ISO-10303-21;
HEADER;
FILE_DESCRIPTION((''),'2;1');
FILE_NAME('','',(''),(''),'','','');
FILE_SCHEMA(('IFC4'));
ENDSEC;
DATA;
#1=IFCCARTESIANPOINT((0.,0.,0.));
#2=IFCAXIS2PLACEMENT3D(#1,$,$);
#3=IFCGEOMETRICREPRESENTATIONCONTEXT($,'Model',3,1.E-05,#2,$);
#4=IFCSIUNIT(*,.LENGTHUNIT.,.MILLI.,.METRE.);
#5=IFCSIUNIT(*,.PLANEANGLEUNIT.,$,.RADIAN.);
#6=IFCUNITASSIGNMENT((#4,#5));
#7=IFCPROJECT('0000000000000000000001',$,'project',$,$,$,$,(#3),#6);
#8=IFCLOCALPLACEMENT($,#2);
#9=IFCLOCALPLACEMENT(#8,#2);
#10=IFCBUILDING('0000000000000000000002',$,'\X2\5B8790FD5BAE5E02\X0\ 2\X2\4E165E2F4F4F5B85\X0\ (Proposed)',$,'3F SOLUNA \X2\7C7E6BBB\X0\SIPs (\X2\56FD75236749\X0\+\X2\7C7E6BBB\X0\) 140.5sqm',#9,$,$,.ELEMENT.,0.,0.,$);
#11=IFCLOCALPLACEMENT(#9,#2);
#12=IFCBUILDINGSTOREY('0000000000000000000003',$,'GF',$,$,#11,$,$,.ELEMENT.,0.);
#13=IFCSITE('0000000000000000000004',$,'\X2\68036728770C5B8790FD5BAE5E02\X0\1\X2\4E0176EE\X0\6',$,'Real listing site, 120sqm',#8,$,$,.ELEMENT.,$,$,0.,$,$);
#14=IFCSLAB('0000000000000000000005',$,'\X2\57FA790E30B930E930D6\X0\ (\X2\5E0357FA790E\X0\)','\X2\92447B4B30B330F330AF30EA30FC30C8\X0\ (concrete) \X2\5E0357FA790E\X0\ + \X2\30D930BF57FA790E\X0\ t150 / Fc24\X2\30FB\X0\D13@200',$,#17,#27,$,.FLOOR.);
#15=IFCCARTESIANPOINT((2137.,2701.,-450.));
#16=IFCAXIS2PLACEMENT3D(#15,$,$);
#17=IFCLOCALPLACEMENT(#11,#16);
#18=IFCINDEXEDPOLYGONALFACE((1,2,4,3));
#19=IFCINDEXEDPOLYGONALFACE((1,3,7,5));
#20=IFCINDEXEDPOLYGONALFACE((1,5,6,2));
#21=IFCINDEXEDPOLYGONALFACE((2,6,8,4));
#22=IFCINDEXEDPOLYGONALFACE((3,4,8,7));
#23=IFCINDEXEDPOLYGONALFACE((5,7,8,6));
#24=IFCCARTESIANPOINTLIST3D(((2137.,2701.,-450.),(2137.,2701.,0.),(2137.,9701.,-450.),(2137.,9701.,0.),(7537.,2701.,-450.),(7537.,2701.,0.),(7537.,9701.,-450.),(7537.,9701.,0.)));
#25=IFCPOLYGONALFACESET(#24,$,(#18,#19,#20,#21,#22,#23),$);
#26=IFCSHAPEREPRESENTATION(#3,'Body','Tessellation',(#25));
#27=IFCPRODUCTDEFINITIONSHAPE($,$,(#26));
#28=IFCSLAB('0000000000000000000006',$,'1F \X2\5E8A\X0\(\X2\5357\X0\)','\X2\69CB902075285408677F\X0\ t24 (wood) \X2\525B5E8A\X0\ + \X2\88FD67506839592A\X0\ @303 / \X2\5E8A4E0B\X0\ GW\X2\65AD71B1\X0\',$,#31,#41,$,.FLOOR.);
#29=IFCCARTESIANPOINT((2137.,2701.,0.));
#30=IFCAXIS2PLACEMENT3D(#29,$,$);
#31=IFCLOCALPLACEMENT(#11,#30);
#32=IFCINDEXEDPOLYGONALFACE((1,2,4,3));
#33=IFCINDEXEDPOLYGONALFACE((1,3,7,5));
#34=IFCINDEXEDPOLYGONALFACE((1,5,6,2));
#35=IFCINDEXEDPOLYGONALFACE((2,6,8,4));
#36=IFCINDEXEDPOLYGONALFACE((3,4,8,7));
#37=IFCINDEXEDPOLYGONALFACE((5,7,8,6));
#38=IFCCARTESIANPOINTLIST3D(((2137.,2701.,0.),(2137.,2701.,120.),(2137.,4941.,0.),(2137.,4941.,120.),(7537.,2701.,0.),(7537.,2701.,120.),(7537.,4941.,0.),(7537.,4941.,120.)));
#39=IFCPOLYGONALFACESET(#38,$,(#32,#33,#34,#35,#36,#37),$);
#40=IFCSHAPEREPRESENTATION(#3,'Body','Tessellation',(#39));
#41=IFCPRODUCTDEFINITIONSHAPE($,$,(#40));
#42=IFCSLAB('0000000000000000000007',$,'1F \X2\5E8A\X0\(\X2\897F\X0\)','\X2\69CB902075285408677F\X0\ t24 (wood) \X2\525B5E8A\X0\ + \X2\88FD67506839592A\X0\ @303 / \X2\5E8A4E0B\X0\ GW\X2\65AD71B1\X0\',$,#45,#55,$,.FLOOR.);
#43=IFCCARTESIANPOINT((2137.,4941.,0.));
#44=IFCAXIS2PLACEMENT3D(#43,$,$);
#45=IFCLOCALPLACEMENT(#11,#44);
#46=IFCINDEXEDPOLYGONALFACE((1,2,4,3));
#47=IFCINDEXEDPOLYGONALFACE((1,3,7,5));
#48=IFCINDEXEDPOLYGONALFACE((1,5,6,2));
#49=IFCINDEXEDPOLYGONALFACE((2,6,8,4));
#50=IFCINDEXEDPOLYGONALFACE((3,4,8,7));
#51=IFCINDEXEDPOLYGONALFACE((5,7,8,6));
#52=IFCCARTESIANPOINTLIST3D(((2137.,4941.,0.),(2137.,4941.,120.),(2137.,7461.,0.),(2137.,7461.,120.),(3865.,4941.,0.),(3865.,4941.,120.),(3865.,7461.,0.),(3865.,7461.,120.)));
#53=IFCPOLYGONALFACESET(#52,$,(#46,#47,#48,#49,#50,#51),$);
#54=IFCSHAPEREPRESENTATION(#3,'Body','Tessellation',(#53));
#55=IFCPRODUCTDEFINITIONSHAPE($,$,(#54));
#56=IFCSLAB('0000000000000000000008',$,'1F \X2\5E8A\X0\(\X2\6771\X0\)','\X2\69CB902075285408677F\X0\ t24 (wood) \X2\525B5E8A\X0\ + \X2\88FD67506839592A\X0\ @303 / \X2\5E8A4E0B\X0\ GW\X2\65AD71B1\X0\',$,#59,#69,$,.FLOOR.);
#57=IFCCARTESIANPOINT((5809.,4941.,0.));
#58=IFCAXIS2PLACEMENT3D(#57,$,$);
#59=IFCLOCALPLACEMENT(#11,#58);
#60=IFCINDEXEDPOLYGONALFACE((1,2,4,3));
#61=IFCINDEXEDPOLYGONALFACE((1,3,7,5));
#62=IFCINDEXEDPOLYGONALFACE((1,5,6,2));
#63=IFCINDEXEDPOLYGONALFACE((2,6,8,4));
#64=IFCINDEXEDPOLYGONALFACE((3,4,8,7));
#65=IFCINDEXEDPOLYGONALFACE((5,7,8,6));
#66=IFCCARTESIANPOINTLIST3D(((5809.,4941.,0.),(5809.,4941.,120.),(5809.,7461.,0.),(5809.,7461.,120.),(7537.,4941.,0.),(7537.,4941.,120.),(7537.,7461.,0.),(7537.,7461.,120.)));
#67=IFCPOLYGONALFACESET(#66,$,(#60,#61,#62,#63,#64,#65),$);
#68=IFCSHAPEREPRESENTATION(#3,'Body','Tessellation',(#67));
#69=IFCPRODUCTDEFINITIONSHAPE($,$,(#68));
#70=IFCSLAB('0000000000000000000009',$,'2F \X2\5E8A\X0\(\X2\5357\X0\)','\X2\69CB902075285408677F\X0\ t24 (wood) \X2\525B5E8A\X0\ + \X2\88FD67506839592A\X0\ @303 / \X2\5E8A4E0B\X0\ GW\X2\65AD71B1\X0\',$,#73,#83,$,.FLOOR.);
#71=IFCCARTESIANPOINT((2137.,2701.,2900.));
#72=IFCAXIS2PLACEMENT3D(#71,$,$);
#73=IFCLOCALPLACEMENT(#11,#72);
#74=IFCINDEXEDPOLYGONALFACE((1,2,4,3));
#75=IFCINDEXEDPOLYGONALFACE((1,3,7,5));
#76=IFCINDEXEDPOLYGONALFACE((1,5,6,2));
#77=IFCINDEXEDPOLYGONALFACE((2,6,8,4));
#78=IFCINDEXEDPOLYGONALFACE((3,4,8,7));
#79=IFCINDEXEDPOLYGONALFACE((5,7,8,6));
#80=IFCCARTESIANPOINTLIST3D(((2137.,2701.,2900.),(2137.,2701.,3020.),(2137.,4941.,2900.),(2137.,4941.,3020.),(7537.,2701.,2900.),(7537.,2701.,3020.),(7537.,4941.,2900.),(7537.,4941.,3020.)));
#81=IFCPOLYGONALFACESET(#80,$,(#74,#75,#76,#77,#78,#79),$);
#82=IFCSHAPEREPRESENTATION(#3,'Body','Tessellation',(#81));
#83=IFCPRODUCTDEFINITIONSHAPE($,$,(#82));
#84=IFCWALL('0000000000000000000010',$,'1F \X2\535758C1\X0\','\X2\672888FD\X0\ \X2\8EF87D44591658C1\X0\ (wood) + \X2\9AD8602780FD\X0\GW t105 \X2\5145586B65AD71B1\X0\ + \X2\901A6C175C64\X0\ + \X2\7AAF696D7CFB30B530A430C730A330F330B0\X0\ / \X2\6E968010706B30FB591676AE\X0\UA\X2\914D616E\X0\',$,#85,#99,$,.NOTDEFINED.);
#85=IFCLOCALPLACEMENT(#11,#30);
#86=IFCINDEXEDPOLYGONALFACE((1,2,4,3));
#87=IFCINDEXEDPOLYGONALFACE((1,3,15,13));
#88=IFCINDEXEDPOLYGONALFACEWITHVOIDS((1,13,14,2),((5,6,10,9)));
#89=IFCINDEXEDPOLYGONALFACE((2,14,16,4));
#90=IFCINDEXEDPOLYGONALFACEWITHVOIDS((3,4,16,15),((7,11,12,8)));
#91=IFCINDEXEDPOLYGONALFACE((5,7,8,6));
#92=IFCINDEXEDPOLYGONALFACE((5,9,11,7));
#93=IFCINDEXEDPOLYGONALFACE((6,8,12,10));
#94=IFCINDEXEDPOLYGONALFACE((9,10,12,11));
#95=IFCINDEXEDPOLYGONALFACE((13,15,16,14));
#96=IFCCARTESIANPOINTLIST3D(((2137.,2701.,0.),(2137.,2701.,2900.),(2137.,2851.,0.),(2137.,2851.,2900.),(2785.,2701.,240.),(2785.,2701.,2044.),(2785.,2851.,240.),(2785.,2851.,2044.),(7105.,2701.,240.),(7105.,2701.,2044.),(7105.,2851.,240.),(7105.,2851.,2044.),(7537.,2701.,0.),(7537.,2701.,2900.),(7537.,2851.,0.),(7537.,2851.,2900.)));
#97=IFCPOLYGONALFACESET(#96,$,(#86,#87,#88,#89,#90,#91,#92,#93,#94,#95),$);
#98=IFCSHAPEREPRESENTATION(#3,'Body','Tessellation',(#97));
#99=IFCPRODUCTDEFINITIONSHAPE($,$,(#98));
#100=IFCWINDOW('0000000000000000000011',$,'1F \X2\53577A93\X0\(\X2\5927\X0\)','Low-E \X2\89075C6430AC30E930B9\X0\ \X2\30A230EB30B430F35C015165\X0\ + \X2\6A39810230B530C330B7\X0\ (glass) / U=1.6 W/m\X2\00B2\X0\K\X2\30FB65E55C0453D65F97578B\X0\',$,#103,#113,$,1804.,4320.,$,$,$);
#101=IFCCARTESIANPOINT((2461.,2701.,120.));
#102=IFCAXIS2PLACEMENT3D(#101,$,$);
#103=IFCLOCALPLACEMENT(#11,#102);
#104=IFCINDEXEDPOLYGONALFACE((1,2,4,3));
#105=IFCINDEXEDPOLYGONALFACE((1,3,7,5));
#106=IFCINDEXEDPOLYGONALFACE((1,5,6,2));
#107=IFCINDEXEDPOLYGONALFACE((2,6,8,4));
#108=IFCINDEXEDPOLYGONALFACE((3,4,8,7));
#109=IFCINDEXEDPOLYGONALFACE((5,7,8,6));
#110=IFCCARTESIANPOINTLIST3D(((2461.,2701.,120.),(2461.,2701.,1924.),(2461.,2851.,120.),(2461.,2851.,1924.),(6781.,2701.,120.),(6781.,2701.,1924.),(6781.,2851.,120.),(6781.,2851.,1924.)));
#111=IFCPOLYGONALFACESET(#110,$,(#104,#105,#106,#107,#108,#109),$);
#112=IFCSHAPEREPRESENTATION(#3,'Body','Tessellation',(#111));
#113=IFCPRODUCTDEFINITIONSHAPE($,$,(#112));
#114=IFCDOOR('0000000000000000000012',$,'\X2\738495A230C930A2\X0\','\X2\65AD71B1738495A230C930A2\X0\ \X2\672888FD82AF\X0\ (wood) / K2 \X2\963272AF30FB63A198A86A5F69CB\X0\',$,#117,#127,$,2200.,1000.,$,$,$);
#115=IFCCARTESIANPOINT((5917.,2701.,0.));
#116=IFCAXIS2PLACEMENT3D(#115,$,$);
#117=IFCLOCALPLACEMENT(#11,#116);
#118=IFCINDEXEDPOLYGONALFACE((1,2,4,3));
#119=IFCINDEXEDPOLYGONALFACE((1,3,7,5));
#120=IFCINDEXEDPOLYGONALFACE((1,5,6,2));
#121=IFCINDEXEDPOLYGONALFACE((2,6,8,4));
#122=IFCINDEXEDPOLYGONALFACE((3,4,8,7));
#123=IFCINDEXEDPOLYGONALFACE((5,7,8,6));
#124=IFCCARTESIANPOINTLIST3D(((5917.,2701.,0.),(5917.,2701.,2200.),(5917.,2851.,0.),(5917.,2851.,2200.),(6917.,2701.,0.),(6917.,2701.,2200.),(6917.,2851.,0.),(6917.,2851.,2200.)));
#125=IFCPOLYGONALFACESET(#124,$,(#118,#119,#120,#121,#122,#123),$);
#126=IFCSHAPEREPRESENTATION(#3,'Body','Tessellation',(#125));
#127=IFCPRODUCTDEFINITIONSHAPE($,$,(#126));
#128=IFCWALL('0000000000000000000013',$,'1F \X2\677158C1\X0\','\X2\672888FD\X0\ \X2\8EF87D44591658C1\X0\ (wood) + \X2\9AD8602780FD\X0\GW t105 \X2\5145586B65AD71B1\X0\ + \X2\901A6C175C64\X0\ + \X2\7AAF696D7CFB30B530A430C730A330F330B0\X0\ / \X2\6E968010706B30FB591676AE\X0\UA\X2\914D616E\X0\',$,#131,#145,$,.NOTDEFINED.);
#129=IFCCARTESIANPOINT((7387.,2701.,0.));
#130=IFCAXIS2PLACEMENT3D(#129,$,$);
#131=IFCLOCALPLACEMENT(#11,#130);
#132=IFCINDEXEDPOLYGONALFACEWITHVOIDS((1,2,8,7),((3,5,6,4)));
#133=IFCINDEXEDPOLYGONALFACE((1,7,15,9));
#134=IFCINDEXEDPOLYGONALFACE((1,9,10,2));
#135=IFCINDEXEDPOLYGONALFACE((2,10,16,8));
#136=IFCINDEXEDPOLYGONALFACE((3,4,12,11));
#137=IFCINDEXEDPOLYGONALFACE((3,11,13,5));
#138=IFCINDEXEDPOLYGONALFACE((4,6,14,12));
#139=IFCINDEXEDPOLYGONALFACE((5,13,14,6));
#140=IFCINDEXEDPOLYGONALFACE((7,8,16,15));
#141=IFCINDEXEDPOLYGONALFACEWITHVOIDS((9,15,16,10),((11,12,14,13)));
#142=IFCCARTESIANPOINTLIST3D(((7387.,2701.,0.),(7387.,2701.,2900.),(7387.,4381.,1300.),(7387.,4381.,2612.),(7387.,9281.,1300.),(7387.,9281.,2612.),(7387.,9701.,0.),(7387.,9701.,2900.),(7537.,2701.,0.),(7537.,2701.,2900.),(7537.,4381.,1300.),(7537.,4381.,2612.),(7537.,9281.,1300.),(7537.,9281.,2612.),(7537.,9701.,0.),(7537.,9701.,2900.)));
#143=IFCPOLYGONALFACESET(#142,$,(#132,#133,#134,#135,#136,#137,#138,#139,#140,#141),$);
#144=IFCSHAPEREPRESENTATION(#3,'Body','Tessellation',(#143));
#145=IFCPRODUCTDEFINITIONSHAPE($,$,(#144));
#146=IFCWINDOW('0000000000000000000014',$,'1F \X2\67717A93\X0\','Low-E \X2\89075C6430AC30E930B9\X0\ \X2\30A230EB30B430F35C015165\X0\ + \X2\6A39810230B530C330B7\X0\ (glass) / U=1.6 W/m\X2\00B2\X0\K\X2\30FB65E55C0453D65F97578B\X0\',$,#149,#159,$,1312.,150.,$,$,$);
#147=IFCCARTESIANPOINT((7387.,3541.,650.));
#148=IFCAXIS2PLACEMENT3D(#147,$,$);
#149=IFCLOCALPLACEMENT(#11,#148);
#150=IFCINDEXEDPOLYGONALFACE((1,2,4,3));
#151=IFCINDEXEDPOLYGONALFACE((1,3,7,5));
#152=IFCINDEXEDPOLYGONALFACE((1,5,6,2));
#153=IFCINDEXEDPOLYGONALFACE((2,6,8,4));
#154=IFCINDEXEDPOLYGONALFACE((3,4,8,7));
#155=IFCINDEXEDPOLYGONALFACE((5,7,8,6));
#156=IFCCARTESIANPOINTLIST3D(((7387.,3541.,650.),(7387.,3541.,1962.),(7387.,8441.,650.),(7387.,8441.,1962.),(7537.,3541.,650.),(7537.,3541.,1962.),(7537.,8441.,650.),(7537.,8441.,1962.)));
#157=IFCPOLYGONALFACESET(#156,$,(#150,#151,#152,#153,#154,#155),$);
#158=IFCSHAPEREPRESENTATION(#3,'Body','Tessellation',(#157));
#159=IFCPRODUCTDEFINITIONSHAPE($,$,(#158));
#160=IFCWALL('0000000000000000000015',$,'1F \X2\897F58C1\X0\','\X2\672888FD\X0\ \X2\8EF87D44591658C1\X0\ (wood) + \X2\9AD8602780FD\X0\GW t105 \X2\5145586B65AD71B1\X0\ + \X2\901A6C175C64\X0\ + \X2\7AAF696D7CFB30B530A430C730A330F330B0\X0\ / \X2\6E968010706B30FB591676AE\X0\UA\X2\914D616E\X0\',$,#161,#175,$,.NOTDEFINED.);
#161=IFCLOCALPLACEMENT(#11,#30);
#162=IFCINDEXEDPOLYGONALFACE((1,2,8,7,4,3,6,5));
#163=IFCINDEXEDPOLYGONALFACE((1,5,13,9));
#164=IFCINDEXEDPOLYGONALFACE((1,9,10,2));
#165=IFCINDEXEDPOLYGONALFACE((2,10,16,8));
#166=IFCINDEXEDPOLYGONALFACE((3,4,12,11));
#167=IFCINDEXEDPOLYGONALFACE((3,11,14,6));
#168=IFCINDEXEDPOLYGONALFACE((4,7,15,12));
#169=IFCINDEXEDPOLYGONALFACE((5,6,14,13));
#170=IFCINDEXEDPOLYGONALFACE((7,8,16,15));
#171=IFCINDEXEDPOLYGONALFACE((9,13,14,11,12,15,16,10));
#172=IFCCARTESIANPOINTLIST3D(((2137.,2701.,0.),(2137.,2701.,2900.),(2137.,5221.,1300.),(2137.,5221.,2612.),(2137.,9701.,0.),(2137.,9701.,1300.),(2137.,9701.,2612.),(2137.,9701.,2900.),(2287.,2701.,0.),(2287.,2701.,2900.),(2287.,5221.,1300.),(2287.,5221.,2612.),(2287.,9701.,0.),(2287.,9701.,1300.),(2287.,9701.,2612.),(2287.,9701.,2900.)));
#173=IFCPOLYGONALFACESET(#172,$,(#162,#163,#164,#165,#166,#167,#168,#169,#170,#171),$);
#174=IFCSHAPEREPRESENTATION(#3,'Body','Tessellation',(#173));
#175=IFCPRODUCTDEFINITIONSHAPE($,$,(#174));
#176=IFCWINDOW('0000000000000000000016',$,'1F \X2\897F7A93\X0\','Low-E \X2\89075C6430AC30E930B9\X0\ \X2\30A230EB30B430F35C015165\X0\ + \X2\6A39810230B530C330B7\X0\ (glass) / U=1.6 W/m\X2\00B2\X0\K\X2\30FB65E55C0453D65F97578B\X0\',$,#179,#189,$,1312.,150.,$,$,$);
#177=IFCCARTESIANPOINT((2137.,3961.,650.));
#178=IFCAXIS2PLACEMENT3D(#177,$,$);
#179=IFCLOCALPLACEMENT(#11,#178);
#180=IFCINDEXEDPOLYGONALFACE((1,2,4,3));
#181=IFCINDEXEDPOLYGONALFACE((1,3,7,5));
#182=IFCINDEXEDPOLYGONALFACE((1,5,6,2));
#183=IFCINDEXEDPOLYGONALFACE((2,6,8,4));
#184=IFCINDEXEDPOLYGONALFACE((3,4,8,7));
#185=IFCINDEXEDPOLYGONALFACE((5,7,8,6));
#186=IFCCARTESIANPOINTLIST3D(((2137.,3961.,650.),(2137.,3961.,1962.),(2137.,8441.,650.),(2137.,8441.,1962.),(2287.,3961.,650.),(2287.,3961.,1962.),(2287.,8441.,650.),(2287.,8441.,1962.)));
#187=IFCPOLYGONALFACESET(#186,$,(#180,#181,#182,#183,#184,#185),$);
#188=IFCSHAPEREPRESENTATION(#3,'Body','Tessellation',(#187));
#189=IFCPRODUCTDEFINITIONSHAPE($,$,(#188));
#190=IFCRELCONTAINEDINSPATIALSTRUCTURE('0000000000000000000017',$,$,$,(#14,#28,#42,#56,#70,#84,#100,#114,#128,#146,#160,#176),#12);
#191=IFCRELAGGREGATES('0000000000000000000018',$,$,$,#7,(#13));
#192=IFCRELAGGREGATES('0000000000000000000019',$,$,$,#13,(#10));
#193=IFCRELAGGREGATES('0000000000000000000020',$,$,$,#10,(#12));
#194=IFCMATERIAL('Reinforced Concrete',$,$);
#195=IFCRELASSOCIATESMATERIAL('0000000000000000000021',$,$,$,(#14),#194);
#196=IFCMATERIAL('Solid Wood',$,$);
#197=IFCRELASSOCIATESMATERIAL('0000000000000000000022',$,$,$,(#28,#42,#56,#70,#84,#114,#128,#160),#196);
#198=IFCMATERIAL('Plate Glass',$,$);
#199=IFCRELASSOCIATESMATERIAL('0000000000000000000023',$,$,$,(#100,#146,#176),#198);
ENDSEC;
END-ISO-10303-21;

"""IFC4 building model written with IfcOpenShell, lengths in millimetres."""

from ifc_helpers import new_model, si_unit, frame, frame_2d, origin, place, context, project, spatial, rectangle, extrude, material, element, fill, save


model = new_model("IFC4")

# Units and contexts
model_context = context("Model", 3, precision=1e-05, world=origin())
ifc_project = project(units=[si_unit("LENGTHUNIT", "METRE", prefix="MILLI"), si_unit("PLANEANGLEUNIT", "RADIAN")], contexts=[model_context])

# Site, building, storey
site_placement = place(None, origin())
site = spatial("IfcSite", under=ifc_project, at=site_placement, Name="栃木県宇都宮市1丁目6", ObjectType="Real listing site, 120sqm", CompositionType="ELEMENT", RefElevation=0.0)
building_placement = place(site_placement, origin())
building = spatial("IfcBuilding", under=site, at=building_placement, Name="宇都宮市 2世帯住宅 (Proposed)", ObjectType="3F SOLUNA 籾殻SIPs (国産杉+籾殻) 140.5sqm", CompositionType="ELEMENT", ElevationOfRefHeight=0.0, ElevationOfTerrain=0.0)
storey_placement = place(building_placement, origin())
storey = spatial("IfcBuildingStorey", under=building, at=storey_placement, Name="GF", CompositionType="ELEMENT", Elevation=0.0)

# Slabs
ifc_material_1 = material(Name="Reinforced Concrete")
slab_1_placement = place(storey_placement, frame((2137.0, 2701.0, -450.0)))
element("IfcSlab", 1, at=slab_1_placement, inside=storey, material=ifc_material_1, Name="基礎スラブ (布基礎)", Description="鉄筋コンクリート (concrete) 布基礎 + ベタ基礎 t150 / Fc24・D13@200", PredefinedType="FLOOR", context=model_context, shape_type="SweptSolid", body=[
    extrude(rectangle(XDim=5400.0, YDim=7000.0, at=frame_2d((2700.0, 3500.0))), frame((2137.0, 2701.0, -450.0)), (0.0, 0.0, 1.0), 450.0),
])
ifc_material_2 = material(Name="Solid Wood")
slab_2_placement = place(storey_placement, frame((2137.0, 2701.0, 0.0)))
element("IfcSlab", 2, at=slab_2_placement, inside=storey, material=ifc_material_2, Name="1F 床(南)", Description="構造用合板 t24 (wood) 剛床 + 製材根太 @303 / 床下 GW断熱", PredefinedType="FLOOR", context=model_context, shape_type="SweptSolid", body=[
    extrude(rectangle(XDim=5400.0, YDim=2240.0, at=frame_2d((2700.0, 1120.0))), frame((2137.0, 2701.0, 0.0)), (0.0, 0.0, 1.0), 120.0),
])
slab_3_placement = place(storey_placement, frame((2137.0, 4941.0, 0.0)))
element("IfcSlab", 3, at=slab_3_placement, inside=storey, material=ifc_material_2, Name="1F 床(西)", Description="構造用合板 t24 (wood) 剛床 + 製材根太 @303 / 床下 GW断熱", PredefinedType="FLOOR", context=model_context, shape_type="SweptSolid", body=[
    extrude(rectangle(XDim=1728.0, YDim=2520.0, at=frame_2d((864.0, 1260.0))), frame((2137.0, 4941.0, 0.0)), (0.0, 0.0, 1.0), 120.0),
])
slab_4_placement = place(storey_placement, frame((5809.0, 4941.0, 0.0)))
element("IfcSlab", 4, at=slab_4_placement, inside=storey, material=ifc_material_2, Name="1F 床(東)", Description="構造用合板 t24 (wood) 剛床 + 製材根太 @303 / 床下 GW断熱", PredefinedType="FLOOR", context=model_context, shape_type="SweptSolid", body=[
    extrude(rectangle(XDim=1728.0, YDim=2520.0, at=frame_2d((864.0, 1260.0))), frame((5809.0, 4941.0, 0.0)), (0.0, 0.0, 1.0), 120.0),
])
slab_5_placement = place(storey_placement, frame((2137.0, 2701.0, 2900.0)))
element("IfcSlab", 5, at=slab_5_placement, inside=storey, material=ifc_material_2, Name="2F 床(南)", Description="構造用合板 t24 (wood) 剛床 + 製材根太 @303 / 床下 GW断熱", PredefinedType="FLOOR", context=model_context, shape_type="SweptSolid", body=[
    extrude(rectangle(XDim=5400.0, YDim=2240.0, at=frame_2d((2700.0, 1120.0))), frame((2137.0, 2701.0, 2900.0)), (0.0, 0.0, 1.0), 120.0),
])

# Wall, openings, window, door
wall_1_placement = place(storey_placement, frame((2137.0, 2701.0, 0.0)))
wall_1 = element("IfcWall", 6, at=wall_1_placement, inside=storey, material=ifc_material_2, Name="1F 南壁", Description="木製 軸組外壁 (wood) + 高性能GW t105 充填断熱 + 通気層 + 窯業系サイディング / 準耐火・外皮UA配慮", PredefinedType="NOTDEFINED", context=model_context, shape_type="SweptSolid", body=[
    extrude(rectangle(XDim=5400.0, YDim=150.0, at=frame_2d((2700.0, 75.0))), frame((2137.0, 2701.0, 0.0)), (0.0, 0.0, 1.0), 2900.0),
])
opening_1_placement = place(storey_placement, frame((2461.0, 2701.0, 120.0)))
opening_1 = element("IfcOpeningElement", 7, at=opening_1_placement, cuts=wall_1, PredefinedType="NOTDEFINED", context=model_context, shape_type="SweptSolid", body=[
    extrude(rectangle(XDim=4320.0, YDim=150.0, at=frame_2d((2160.0, 75.0))), frame((2461.0, 2701.0, 120.0)), (0.0, 0.0, 1.0), 1804.0),
])
opening_2_placement = place(storey_placement, frame((5917.0, 2701.0, 0.0)))
opening_2 = element("IfcOpeningElement", 8, at=opening_2_placement, cuts=wall_1, PredefinedType="NOTDEFINED", context=model_context, shape_type="SweptSolid", body=[
    extrude(rectangle(XDim=1000.0, YDim=150.0, at=frame_2d((500.0, 75.0))), frame((5917.0, 2701.0, 0.0)), (0.0, 0.0, 1.0), 2200.0),
])
ifc_material_3 = material(Name="Plate Glass")
window_1_placement = place(storey_placement, frame((2461.0, 2701.0, 120.0)))
window_1 = element("IfcWindow", 9, at=window_1_placement, inside=storey, material=ifc_material_3, Name="1F 南窓(大)", Description="Low-E 複層ガラス アルゴン封入 + 樹脂サッシ (glass) / U=1.6 W/m²K・日射取得型", OverallHeight=1804.0, OverallWidth=4320.0, context=model_context, shape_type="SweptSolid", body=[
    extrude(rectangle(XDim=4320.0, YDim=150.0, at=frame_2d((2160.0, 75.0))), frame((2461.0, 2701.0, 120.0)), (0.0, 0.0, 1.0), 1804.0),
])
fill(opening_1, window_1)
door_placement = place(storey_placement, frame((5917.0, 2701.0, 0.0)))
door = element("IfcDoor", 10, at=door_placement, inside=storey, material=ifc_material_2, Name="玄関ドア", Description="断熱玄関ドア 木製芯 (wood) / K2 防犯・採風機構", OverallHeight=2200.0, OverallWidth=1000.0, context=model_context, shape_type="SweptSolid", body=[
    extrude(rectangle(XDim=1000.0, YDim=150.0, at=frame_2d((500.0, 75.0))), frame((5917.0, 2701.0, 0.0)), (0.0, 0.0, 1.0), 2200.0),
])
fill(opening_2, door)

# Walls, openings, windows
wall_2_placement = place(storey_placement, frame((7387.0, 2701.0, 0.0)))
wall_2 = element("IfcWall", 11, at=wall_2_placement, inside=storey, material=ifc_material_2, Name="1F 東壁", Description="木製 軸組外壁 (wood) + 高性能GW t105 充填断熱 + 通気層 + 窯業系サイディング / 準耐火・外皮UA配慮", PredefinedType="NOTDEFINED", context=model_context, shape_type="SweptSolid", body=[
    extrude(rectangle(XDim=150.0, YDim=7000.0, at=frame_2d((75.0, 3500.0))), frame((7387.0, 2701.0, 0.0)), (0.0, 0.0, 1.0), 2900.0),
])
opening_3_placement = place(storey_placement, frame((7387.0, 3541.0, 650.0)))
opening_3 = element("IfcOpeningElement", 12, at=opening_3_placement, cuts=wall_2, PredefinedType="NOTDEFINED", context=model_context, shape_type="SweptSolid", body=[
    extrude(rectangle(XDim=150.0, YDim=4900.0, at=frame_2d((75.0, 2450.0))), frame((7387.0, 3541.0, 650.0)), (0.0, 0.0, 1.0), 1312.0),
])
window_2_placement = place(storey_placement, frame((7387.0, 3541.0, 650.0)))
window_2 = element("IfcWindow", 13, at=window_2_placement, inside=storey, material=ifc_material_3, Name="1F 東窓", Description="Low-E 複層ガラス アルゴン封入 + 樹脂サッシ (glass) / U=1.6 W/m²K・日射取得型", OverallHeight=1312.0, OverallWidth=150.0, context=model_context, shape_type="SweptSolid", body=[
    extrude(rectangle(XDim=150.0, YDim=4900.0, at=frame_2d((75.0, 2450.0))), frame((7387.0, 3541.0, 650.0)), (0.0, 0.0, 1.0), 1312.0),
])
fill(opening_3, window_2)
wall_3_placement = place(storey_placement, frame((2137.0, 2701.0, 0.0)))
wall_3 = element("IfcWall", 14, at=wall_3_placement, inside=storey, material=ifc_material_2, Name="1F 西壁", Description="木製 軸組外壁 (wood) + 高性能GW t105 充填断熱 + 通気層 + 窯業系サイディング / 準耐火・外皮UA配慮", PredefinedType="NOTDEFINED", context=model_context, shape_type="SweptSolid", body=[
    extrude(rectangle(XDim=150.0, YDim=7000.0, at=frame_2d((75.0, 3500.0))), frame((2137.0, 2701.0, 0.0)), (0.0, 0.0, 1.0), 2900.0),
])
opening_4_placement = place(storey_placement, frame((2137.0, 3961.0, 650.0)))
opening_4 = element("IfcOpeningElement", 15, at=opening_4_placement, cuts=wall_3, PredefinedType="NOTDEFINED", context=model_context, shape_type="SweptSolid", body=[
    extrude(rectangle(XDim=150.0, YDim=4480.0, at=frame_2d((75.0, 2240.0))), frame((2137.0, 3961.0, 650.0)), (0.0, 0.0, 1.0), 1312.0),
])
window_3_placement = place(storey_placement, frame((2137.0, 3961.0, 650.0)))
window_3 = element("IfcWindow", 16, at=window_3_placement, inside=storey, material=ifc_material_3, Name="1F 西窓", Description="Low-E 複層ガラス アルゴン封入 + 樹脂サッシ (glass) / U=1.6 W/m²K・日射取得型", OverallHeight=1312.0, OverallWidth=150.0, context=model_context, shape_type="SweptSolid", body=[
    extrude(rectangle(XDim=150.0, YDim=4480.0, at=frame_2d((75.0, 2240.0))), frame((2137.0, 3961.0, 650.0)), (0.0, 0.0, 1.0), 1312.0),
])
fill(opening_4, window_3)

save(model, "model.ifc")
